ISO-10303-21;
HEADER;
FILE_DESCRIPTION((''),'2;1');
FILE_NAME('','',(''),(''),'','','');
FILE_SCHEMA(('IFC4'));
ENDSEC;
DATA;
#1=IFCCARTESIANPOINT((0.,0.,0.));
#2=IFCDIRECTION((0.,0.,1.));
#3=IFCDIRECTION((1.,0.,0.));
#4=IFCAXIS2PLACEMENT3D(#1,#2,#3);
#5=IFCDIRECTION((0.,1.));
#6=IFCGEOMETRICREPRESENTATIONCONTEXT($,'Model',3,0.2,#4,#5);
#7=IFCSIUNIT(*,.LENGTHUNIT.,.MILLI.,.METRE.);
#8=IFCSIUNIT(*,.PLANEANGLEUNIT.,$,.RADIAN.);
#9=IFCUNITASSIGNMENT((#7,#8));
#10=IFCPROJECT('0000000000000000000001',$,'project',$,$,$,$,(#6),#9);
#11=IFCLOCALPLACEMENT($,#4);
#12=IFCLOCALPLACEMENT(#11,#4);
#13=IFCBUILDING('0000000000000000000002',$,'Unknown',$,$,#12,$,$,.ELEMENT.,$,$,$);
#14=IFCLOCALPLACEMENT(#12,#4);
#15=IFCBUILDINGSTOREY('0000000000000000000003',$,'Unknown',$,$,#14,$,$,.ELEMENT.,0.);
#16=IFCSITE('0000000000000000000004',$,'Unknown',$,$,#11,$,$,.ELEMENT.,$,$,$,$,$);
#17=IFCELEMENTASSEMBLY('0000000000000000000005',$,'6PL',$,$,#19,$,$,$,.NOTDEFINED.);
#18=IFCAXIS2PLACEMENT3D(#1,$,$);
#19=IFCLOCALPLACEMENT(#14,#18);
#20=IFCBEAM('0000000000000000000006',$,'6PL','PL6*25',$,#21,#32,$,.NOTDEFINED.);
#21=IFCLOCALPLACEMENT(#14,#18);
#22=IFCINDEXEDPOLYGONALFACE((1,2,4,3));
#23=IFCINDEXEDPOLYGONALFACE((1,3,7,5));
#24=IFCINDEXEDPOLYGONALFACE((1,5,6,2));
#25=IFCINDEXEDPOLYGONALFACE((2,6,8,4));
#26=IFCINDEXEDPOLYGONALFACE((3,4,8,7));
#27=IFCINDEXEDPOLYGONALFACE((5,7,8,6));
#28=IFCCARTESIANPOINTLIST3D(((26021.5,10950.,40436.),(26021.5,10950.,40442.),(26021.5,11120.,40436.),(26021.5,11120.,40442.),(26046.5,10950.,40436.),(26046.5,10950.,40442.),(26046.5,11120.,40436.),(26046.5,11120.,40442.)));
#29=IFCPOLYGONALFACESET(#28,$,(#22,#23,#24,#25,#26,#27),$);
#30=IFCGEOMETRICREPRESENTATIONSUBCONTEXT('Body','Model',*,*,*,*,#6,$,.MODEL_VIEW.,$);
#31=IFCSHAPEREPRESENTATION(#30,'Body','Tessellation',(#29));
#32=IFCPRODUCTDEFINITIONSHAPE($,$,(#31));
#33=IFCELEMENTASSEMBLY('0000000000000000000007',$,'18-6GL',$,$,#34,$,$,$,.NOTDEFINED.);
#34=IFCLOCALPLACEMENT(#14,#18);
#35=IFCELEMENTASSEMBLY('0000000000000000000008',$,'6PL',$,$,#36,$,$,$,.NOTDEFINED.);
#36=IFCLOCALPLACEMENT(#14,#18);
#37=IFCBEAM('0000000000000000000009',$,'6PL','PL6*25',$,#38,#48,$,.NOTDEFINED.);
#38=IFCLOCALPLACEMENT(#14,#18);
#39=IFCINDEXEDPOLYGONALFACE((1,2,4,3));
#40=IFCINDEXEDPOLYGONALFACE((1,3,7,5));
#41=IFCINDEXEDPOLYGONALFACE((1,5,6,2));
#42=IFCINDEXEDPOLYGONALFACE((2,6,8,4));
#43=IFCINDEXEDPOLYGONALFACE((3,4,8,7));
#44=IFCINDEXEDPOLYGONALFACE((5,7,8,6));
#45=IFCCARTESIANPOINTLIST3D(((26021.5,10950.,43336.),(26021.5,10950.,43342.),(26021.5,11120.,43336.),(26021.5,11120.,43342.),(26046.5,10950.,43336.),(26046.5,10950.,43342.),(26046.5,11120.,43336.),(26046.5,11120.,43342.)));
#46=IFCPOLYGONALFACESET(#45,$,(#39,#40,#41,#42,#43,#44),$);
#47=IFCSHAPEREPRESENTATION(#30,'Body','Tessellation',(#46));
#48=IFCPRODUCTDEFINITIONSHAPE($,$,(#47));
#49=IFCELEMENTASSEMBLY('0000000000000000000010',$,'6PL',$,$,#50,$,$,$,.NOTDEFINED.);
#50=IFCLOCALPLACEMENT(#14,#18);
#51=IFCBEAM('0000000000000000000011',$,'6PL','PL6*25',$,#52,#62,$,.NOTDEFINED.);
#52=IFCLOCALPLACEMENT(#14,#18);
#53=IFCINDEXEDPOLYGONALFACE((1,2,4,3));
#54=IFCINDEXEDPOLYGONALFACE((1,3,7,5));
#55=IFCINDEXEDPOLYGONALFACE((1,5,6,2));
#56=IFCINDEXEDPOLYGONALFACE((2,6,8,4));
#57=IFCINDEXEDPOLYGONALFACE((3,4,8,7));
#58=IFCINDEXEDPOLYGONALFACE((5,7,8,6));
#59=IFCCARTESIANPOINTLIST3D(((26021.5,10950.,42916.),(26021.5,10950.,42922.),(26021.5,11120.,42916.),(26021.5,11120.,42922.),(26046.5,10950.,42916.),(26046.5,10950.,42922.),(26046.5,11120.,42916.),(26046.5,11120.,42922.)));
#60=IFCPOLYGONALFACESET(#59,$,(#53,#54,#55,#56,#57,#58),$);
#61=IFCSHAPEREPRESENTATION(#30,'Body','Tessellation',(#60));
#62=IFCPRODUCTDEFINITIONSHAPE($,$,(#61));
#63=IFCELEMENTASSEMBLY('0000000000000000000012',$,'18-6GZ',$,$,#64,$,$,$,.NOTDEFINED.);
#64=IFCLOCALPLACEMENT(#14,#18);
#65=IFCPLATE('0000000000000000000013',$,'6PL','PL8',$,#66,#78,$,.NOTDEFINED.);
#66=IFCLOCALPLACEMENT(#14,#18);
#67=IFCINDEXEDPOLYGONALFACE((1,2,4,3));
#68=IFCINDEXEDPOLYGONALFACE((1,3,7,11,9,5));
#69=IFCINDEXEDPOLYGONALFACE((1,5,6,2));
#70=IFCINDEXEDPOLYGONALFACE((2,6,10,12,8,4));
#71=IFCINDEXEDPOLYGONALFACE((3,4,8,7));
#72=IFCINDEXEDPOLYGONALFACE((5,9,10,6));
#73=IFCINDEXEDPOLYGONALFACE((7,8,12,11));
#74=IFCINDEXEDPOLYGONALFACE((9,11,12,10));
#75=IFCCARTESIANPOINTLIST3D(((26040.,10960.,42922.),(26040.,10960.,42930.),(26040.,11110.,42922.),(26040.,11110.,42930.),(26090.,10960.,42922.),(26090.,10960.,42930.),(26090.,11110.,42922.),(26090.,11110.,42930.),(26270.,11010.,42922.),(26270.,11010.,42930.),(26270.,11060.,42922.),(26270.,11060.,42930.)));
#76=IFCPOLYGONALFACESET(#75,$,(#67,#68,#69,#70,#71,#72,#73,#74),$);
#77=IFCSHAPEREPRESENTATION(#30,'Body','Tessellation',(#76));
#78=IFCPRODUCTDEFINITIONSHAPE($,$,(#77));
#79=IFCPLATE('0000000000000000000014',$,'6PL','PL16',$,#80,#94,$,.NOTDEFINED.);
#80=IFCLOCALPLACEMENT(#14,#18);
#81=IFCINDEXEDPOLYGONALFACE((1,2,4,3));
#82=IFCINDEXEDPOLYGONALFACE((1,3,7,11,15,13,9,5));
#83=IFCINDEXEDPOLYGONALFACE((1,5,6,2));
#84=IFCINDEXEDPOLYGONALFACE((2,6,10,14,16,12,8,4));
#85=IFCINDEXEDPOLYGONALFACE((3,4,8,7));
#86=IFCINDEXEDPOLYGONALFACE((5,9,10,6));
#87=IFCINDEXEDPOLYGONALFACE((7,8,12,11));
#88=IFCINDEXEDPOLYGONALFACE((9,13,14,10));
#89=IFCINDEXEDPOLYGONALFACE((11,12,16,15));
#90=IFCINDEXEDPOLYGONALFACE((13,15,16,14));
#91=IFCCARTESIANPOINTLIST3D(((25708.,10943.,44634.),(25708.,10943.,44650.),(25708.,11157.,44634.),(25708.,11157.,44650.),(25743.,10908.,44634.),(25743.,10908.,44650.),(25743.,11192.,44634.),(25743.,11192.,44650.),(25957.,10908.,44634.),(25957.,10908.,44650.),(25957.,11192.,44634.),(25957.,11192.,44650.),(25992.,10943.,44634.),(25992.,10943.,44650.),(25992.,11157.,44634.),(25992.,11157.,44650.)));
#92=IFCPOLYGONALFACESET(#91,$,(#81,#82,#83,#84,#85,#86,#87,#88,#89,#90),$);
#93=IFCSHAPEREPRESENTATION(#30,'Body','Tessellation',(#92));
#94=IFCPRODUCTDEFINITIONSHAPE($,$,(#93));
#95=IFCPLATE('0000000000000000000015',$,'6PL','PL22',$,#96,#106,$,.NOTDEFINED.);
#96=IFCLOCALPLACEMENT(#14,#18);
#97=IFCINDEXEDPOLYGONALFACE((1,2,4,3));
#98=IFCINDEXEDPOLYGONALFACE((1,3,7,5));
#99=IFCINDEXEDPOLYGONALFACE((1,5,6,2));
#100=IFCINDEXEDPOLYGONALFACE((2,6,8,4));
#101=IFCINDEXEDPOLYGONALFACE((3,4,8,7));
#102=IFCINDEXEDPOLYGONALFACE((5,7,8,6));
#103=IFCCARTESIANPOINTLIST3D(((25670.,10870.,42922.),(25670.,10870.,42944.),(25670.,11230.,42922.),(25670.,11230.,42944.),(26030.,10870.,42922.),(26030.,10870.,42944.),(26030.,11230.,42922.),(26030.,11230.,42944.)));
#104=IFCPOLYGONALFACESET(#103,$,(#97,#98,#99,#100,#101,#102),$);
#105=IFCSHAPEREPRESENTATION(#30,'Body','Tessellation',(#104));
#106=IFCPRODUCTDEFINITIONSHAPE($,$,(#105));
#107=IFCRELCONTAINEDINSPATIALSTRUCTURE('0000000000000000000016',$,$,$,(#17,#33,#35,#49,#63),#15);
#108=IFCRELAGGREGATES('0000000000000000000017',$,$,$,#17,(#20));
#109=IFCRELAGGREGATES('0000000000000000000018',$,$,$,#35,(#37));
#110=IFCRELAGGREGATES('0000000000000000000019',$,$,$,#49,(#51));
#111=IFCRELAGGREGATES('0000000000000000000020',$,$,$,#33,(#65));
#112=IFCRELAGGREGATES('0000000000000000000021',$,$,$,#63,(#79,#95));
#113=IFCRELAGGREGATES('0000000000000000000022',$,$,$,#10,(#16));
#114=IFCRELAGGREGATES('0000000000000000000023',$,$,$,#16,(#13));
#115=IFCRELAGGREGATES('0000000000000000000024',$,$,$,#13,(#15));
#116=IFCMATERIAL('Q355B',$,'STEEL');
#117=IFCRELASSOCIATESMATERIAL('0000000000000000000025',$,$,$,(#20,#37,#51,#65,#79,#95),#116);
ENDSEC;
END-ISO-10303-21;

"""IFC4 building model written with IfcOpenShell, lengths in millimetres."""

from ifc_helpers import new_model, si_unit, direction, frame, origin_with_axes, place, context, subcontext, project, spatial, line, indexed_curve, outline, extrude, material, element, aggregate, save


model = new_model("IFC4")

# Units and contexts
model_context = context("Model", 3, precision=0.2, world=origin_with_axes(), true_north=direction((0.0, 1.0)))
body_context = subcontext(model_context, "Body", "Model", "MODEL_VIEW")
ifc_project = project(units=[si_unit("LENGTHUNIT", "METRE", prefix="MILLI"), si_unit("PLANEANGLEUNIT", "RADIAN")], contexts=[model_context])

# Site, building, storey
site_placement = place(None, origin_with_axes())
site = spatial("IfcSite", under=ifc_project, at=site_placement, Name="Unknown", CompositionType="ELEMENT")
building_placement = place(site_placement, origin_with_axes())
building = spatial("IfcBuilding", under=site, at=building_placement, Name="Unknown", CompositionType="ELEMENT")
storey_placement = place(building_placement, origin_with_axes())
storey = spatial("IfcBuildingStorey", under=building, at=storey_placement, Name="Unknown", CompositionType="ELEMENT", Elevation=0.0)

# Shared definitions
ifc_material_1 = material(Name="Q355B", Category="STEEL")

# Element assembly, beam
assembly_1_placement = place(storey_placement, frame((26034.0, 10950.0, 40439.0), z_axis=(0.0, 0.0, -1.0), x_axis=(0.0, 1.0, 0.0)))
assembly_1 = element("IfcElementAssembly", 1, at=assembly_1_placement, inside=storey, Name="6PL", PredefinedType="NOTDEFINED")
beam_1_placement = place(assembly_1_placement, origin_with_axes())
beam_1 = element("IfcBeam", 2, at=beam_1_placement, material=ifc_material_1, Name="6PL", Description="PL6*25", PredefinedType="NOTDEFINED", context=body_context, shape_type="SolidModel", body=[
    extrude(outline(indexed_curve([(-3.0, -12.5), (3.0, -12.5), (3.0, 12.5), (-3.0, 12.5)], segments=[line(1, 2, 3, 4, 1)])), frame((0.0, 0.0, 0.0), z_axis=(-1.0, 0.0, 0.0), x_axis=(0.0, 0.0, 1.0)), (0.0, 0.0, -1.0), 170.0),
])
aggregate(assembly_1, [beam_1])

# Element assembly
assembly_2_placement = place(storey_placement, frame((26000.0, 11035.0, 43140.0), z_axis=(0.0, -1.0, 0.0), x_axis=(1.0, 0.0, 0.0)))
assembly_2 = element("IfcElementAssembly", 3, at=assembly_2_placement, inside=storey, Name="18-6GL", PredefinedType="NOTDEFINED")

# Element assemblies, beams
assembly_3_placement = place(storey_placement, frame((26034.0, 10950.0, 43339.0), z_axis=(0.0, 0.0, -1.0), x_axis=(0.0, 1.0, 0.0)))
assembly_3 = element("IfcElementAssembly", 4, at=assembly_3_placement, inside=storey, Name="6PL", PredefinedType="NOTDEFINED")
beam_2_placement = place(assembly_3_placement, origin_with_axes())
beam_2 = element("IfcBeam", 5, at=beam_2_placement, material=ifc_material_1, Name="6PL", Description="PL6*25", PredefinedType="NOTDEFINED", context=body_context, shape_type="SolidModel", body=[
    extrude(outline(indexed_curve([(-3.0, -12.5), (3.0, -12.5), (3.0, 12.5), (-3.0, 12.5)], segments=[line(1, 2, 3, 4, 1)])), frame((0.0, 0.0, 0.0), z_axis=(-1.0, 0.0, 0.0), x_axis=(0.0, 0.0, 1.0)), (0.0, 0.0, -1.0), 170.0),
])
aggregate(assembly_3, [beam_2])
assembly_4_placement = place(storey_placement, frame((26034.0, 10950.0, 42919.0), z_axis=(0.0, 0.0, -1.0), x_axis=(0.0, 1.0, 0.0)))
assembly_4 = element("IfcElementAssembly", 6, at=assembly_4_placement, inside=storey, Name="6PL", PredefinedType="NOTDEFINED")
beam_3_placement = place(assembly_4_placement, origin_with_axes())
beam_3 = element("IfcBeam", 7, at=beam_3_placement, material=ifc_material_1, Name="6PL", Description="PL6*25", PredefinedType="NOTDEFINED", context=body_context, shape_type="SolidModel", body=[
    extrude(outline(indexed_curve([(-3.0, -12.5), (3.0, -12.5), (3.0, 12.5), (-3.0, 12.5)], segments=[line(1, 2, 3, 4, 1)])), frame((0.0, 0.0, 0.0), z_axis=(-1.0, 0.0, 0.0), x_axis=(0.0, 0.0, 1.0)), (0.0, 0.0, -1.0), 170.0),
])
aggregate(assembly_4, [beam_3])

# Element assembly
assembly_5_placement = place(storey_placement, frame((25850.0, 11050.0, 35950.0), z_axis=(-1.0, 0.0, 0.0), x_axis=(0.0, 0.0, 1.0)))
assembly_5 = element("IfcElementAssembly", 8, at=assembly_5_placement, inside=storey, Name="18-6GZ", PredefinedType="NOTDEFINED")

# Plates
plate_1_placement = place(assembly_2_placement, frame((90.0, -214.0, -75.0), z_axis=(0.0, 1.0, 0.0), x_axis=(-1.0, 0.0, 0.0)))
plate_1 = element("IfcPlate", 9, at=plate_1_placement, material=ifc_material_1, Name="6PL", Description="PL8", PredefinedType="NOTDEFINED", context=body_context, shape_type="SolidModel", body=[
    extrude(outline(indexed_curve([(0.0, 0.0), (50.0, 0.0), (50.0, 150.0), (0.0, 150.0), (-180.0, 100.0), (-180.0, 50.0)], segments=[line(1, 2, 3, 4, 5, 6, 1)])), frame((0.0, 0.0, 4.0), z_axis=(0.0, 0.0, 1.0), x_axis=(1.0, 0.0, 0.0)), (0.0, 0.0, -1.0), 8.0),
])
aggregate(assembly_2, [plate_1])
plate_2_placement = place(assembly_5_placement, frame((8692.0, -142.0, -142.0), z_axis=(-1.0, 0.0, 0.0), x_axis=(0.0, 0.0, 1.0)))
plate_2 = element("IfcPlate", 10, at=plate_2_placement, material=ifc_material_1, Name="6PL", Description="PL16", PredefinedType="NOTDEFINED", context=body_context, shape_type="SolidModel", body=[
    extrude(outline(indexed_curve([(0.0, 35.0), (35.0, 0.0), (249.0, 0.0), (284.0, 35.0), (284.0, 249.0), (249.0, 284.0), (35.0, 284.0), (0.0, 249.0)], segments=[line(1, 2, 3, 4, 5, 6, 7, 8, 1)])), frame((0.0, 0.0, 8.0), z_axis=(0.0, 0.0, 1.0), x_axis=(1.0, 0.0, 0.0)), (0.0, 0.0, -1.0), 16.0),
])
plate_3_placement = place(assembly_5_placement, frame((6983.0, -180.0, -180.0), z_axis=(-1.0, 0.0, 0.0), x_axis=(0.0, 0.0, 1.0)))
plate_3 = element("IfcPlate", 11, at=plate_3_placement, material=ifc_material_1, Name="6PL", Description="PL22", PredefinedType="NOTDEFINED", context=body_context, shape_type="SolidModel", body=[
    extrude(outline(indexed_curve([(0.0, 0.0), (360.0, 0.0), (360.0, 360.0), (0.0, 360.0)], segments=[line(1, 2, 3, 4, 1)])), frame((0.0, 0.0, 11.0), z_axis=(0.0, 0.0, 1.0), x_axis=(1.0, 0.0, 0.0)), (0.0, 0.0, -1.0), 22.0),
])

aggregate(assembly_5, [plate_2, plate_3])

save(model, "model.ifc")
